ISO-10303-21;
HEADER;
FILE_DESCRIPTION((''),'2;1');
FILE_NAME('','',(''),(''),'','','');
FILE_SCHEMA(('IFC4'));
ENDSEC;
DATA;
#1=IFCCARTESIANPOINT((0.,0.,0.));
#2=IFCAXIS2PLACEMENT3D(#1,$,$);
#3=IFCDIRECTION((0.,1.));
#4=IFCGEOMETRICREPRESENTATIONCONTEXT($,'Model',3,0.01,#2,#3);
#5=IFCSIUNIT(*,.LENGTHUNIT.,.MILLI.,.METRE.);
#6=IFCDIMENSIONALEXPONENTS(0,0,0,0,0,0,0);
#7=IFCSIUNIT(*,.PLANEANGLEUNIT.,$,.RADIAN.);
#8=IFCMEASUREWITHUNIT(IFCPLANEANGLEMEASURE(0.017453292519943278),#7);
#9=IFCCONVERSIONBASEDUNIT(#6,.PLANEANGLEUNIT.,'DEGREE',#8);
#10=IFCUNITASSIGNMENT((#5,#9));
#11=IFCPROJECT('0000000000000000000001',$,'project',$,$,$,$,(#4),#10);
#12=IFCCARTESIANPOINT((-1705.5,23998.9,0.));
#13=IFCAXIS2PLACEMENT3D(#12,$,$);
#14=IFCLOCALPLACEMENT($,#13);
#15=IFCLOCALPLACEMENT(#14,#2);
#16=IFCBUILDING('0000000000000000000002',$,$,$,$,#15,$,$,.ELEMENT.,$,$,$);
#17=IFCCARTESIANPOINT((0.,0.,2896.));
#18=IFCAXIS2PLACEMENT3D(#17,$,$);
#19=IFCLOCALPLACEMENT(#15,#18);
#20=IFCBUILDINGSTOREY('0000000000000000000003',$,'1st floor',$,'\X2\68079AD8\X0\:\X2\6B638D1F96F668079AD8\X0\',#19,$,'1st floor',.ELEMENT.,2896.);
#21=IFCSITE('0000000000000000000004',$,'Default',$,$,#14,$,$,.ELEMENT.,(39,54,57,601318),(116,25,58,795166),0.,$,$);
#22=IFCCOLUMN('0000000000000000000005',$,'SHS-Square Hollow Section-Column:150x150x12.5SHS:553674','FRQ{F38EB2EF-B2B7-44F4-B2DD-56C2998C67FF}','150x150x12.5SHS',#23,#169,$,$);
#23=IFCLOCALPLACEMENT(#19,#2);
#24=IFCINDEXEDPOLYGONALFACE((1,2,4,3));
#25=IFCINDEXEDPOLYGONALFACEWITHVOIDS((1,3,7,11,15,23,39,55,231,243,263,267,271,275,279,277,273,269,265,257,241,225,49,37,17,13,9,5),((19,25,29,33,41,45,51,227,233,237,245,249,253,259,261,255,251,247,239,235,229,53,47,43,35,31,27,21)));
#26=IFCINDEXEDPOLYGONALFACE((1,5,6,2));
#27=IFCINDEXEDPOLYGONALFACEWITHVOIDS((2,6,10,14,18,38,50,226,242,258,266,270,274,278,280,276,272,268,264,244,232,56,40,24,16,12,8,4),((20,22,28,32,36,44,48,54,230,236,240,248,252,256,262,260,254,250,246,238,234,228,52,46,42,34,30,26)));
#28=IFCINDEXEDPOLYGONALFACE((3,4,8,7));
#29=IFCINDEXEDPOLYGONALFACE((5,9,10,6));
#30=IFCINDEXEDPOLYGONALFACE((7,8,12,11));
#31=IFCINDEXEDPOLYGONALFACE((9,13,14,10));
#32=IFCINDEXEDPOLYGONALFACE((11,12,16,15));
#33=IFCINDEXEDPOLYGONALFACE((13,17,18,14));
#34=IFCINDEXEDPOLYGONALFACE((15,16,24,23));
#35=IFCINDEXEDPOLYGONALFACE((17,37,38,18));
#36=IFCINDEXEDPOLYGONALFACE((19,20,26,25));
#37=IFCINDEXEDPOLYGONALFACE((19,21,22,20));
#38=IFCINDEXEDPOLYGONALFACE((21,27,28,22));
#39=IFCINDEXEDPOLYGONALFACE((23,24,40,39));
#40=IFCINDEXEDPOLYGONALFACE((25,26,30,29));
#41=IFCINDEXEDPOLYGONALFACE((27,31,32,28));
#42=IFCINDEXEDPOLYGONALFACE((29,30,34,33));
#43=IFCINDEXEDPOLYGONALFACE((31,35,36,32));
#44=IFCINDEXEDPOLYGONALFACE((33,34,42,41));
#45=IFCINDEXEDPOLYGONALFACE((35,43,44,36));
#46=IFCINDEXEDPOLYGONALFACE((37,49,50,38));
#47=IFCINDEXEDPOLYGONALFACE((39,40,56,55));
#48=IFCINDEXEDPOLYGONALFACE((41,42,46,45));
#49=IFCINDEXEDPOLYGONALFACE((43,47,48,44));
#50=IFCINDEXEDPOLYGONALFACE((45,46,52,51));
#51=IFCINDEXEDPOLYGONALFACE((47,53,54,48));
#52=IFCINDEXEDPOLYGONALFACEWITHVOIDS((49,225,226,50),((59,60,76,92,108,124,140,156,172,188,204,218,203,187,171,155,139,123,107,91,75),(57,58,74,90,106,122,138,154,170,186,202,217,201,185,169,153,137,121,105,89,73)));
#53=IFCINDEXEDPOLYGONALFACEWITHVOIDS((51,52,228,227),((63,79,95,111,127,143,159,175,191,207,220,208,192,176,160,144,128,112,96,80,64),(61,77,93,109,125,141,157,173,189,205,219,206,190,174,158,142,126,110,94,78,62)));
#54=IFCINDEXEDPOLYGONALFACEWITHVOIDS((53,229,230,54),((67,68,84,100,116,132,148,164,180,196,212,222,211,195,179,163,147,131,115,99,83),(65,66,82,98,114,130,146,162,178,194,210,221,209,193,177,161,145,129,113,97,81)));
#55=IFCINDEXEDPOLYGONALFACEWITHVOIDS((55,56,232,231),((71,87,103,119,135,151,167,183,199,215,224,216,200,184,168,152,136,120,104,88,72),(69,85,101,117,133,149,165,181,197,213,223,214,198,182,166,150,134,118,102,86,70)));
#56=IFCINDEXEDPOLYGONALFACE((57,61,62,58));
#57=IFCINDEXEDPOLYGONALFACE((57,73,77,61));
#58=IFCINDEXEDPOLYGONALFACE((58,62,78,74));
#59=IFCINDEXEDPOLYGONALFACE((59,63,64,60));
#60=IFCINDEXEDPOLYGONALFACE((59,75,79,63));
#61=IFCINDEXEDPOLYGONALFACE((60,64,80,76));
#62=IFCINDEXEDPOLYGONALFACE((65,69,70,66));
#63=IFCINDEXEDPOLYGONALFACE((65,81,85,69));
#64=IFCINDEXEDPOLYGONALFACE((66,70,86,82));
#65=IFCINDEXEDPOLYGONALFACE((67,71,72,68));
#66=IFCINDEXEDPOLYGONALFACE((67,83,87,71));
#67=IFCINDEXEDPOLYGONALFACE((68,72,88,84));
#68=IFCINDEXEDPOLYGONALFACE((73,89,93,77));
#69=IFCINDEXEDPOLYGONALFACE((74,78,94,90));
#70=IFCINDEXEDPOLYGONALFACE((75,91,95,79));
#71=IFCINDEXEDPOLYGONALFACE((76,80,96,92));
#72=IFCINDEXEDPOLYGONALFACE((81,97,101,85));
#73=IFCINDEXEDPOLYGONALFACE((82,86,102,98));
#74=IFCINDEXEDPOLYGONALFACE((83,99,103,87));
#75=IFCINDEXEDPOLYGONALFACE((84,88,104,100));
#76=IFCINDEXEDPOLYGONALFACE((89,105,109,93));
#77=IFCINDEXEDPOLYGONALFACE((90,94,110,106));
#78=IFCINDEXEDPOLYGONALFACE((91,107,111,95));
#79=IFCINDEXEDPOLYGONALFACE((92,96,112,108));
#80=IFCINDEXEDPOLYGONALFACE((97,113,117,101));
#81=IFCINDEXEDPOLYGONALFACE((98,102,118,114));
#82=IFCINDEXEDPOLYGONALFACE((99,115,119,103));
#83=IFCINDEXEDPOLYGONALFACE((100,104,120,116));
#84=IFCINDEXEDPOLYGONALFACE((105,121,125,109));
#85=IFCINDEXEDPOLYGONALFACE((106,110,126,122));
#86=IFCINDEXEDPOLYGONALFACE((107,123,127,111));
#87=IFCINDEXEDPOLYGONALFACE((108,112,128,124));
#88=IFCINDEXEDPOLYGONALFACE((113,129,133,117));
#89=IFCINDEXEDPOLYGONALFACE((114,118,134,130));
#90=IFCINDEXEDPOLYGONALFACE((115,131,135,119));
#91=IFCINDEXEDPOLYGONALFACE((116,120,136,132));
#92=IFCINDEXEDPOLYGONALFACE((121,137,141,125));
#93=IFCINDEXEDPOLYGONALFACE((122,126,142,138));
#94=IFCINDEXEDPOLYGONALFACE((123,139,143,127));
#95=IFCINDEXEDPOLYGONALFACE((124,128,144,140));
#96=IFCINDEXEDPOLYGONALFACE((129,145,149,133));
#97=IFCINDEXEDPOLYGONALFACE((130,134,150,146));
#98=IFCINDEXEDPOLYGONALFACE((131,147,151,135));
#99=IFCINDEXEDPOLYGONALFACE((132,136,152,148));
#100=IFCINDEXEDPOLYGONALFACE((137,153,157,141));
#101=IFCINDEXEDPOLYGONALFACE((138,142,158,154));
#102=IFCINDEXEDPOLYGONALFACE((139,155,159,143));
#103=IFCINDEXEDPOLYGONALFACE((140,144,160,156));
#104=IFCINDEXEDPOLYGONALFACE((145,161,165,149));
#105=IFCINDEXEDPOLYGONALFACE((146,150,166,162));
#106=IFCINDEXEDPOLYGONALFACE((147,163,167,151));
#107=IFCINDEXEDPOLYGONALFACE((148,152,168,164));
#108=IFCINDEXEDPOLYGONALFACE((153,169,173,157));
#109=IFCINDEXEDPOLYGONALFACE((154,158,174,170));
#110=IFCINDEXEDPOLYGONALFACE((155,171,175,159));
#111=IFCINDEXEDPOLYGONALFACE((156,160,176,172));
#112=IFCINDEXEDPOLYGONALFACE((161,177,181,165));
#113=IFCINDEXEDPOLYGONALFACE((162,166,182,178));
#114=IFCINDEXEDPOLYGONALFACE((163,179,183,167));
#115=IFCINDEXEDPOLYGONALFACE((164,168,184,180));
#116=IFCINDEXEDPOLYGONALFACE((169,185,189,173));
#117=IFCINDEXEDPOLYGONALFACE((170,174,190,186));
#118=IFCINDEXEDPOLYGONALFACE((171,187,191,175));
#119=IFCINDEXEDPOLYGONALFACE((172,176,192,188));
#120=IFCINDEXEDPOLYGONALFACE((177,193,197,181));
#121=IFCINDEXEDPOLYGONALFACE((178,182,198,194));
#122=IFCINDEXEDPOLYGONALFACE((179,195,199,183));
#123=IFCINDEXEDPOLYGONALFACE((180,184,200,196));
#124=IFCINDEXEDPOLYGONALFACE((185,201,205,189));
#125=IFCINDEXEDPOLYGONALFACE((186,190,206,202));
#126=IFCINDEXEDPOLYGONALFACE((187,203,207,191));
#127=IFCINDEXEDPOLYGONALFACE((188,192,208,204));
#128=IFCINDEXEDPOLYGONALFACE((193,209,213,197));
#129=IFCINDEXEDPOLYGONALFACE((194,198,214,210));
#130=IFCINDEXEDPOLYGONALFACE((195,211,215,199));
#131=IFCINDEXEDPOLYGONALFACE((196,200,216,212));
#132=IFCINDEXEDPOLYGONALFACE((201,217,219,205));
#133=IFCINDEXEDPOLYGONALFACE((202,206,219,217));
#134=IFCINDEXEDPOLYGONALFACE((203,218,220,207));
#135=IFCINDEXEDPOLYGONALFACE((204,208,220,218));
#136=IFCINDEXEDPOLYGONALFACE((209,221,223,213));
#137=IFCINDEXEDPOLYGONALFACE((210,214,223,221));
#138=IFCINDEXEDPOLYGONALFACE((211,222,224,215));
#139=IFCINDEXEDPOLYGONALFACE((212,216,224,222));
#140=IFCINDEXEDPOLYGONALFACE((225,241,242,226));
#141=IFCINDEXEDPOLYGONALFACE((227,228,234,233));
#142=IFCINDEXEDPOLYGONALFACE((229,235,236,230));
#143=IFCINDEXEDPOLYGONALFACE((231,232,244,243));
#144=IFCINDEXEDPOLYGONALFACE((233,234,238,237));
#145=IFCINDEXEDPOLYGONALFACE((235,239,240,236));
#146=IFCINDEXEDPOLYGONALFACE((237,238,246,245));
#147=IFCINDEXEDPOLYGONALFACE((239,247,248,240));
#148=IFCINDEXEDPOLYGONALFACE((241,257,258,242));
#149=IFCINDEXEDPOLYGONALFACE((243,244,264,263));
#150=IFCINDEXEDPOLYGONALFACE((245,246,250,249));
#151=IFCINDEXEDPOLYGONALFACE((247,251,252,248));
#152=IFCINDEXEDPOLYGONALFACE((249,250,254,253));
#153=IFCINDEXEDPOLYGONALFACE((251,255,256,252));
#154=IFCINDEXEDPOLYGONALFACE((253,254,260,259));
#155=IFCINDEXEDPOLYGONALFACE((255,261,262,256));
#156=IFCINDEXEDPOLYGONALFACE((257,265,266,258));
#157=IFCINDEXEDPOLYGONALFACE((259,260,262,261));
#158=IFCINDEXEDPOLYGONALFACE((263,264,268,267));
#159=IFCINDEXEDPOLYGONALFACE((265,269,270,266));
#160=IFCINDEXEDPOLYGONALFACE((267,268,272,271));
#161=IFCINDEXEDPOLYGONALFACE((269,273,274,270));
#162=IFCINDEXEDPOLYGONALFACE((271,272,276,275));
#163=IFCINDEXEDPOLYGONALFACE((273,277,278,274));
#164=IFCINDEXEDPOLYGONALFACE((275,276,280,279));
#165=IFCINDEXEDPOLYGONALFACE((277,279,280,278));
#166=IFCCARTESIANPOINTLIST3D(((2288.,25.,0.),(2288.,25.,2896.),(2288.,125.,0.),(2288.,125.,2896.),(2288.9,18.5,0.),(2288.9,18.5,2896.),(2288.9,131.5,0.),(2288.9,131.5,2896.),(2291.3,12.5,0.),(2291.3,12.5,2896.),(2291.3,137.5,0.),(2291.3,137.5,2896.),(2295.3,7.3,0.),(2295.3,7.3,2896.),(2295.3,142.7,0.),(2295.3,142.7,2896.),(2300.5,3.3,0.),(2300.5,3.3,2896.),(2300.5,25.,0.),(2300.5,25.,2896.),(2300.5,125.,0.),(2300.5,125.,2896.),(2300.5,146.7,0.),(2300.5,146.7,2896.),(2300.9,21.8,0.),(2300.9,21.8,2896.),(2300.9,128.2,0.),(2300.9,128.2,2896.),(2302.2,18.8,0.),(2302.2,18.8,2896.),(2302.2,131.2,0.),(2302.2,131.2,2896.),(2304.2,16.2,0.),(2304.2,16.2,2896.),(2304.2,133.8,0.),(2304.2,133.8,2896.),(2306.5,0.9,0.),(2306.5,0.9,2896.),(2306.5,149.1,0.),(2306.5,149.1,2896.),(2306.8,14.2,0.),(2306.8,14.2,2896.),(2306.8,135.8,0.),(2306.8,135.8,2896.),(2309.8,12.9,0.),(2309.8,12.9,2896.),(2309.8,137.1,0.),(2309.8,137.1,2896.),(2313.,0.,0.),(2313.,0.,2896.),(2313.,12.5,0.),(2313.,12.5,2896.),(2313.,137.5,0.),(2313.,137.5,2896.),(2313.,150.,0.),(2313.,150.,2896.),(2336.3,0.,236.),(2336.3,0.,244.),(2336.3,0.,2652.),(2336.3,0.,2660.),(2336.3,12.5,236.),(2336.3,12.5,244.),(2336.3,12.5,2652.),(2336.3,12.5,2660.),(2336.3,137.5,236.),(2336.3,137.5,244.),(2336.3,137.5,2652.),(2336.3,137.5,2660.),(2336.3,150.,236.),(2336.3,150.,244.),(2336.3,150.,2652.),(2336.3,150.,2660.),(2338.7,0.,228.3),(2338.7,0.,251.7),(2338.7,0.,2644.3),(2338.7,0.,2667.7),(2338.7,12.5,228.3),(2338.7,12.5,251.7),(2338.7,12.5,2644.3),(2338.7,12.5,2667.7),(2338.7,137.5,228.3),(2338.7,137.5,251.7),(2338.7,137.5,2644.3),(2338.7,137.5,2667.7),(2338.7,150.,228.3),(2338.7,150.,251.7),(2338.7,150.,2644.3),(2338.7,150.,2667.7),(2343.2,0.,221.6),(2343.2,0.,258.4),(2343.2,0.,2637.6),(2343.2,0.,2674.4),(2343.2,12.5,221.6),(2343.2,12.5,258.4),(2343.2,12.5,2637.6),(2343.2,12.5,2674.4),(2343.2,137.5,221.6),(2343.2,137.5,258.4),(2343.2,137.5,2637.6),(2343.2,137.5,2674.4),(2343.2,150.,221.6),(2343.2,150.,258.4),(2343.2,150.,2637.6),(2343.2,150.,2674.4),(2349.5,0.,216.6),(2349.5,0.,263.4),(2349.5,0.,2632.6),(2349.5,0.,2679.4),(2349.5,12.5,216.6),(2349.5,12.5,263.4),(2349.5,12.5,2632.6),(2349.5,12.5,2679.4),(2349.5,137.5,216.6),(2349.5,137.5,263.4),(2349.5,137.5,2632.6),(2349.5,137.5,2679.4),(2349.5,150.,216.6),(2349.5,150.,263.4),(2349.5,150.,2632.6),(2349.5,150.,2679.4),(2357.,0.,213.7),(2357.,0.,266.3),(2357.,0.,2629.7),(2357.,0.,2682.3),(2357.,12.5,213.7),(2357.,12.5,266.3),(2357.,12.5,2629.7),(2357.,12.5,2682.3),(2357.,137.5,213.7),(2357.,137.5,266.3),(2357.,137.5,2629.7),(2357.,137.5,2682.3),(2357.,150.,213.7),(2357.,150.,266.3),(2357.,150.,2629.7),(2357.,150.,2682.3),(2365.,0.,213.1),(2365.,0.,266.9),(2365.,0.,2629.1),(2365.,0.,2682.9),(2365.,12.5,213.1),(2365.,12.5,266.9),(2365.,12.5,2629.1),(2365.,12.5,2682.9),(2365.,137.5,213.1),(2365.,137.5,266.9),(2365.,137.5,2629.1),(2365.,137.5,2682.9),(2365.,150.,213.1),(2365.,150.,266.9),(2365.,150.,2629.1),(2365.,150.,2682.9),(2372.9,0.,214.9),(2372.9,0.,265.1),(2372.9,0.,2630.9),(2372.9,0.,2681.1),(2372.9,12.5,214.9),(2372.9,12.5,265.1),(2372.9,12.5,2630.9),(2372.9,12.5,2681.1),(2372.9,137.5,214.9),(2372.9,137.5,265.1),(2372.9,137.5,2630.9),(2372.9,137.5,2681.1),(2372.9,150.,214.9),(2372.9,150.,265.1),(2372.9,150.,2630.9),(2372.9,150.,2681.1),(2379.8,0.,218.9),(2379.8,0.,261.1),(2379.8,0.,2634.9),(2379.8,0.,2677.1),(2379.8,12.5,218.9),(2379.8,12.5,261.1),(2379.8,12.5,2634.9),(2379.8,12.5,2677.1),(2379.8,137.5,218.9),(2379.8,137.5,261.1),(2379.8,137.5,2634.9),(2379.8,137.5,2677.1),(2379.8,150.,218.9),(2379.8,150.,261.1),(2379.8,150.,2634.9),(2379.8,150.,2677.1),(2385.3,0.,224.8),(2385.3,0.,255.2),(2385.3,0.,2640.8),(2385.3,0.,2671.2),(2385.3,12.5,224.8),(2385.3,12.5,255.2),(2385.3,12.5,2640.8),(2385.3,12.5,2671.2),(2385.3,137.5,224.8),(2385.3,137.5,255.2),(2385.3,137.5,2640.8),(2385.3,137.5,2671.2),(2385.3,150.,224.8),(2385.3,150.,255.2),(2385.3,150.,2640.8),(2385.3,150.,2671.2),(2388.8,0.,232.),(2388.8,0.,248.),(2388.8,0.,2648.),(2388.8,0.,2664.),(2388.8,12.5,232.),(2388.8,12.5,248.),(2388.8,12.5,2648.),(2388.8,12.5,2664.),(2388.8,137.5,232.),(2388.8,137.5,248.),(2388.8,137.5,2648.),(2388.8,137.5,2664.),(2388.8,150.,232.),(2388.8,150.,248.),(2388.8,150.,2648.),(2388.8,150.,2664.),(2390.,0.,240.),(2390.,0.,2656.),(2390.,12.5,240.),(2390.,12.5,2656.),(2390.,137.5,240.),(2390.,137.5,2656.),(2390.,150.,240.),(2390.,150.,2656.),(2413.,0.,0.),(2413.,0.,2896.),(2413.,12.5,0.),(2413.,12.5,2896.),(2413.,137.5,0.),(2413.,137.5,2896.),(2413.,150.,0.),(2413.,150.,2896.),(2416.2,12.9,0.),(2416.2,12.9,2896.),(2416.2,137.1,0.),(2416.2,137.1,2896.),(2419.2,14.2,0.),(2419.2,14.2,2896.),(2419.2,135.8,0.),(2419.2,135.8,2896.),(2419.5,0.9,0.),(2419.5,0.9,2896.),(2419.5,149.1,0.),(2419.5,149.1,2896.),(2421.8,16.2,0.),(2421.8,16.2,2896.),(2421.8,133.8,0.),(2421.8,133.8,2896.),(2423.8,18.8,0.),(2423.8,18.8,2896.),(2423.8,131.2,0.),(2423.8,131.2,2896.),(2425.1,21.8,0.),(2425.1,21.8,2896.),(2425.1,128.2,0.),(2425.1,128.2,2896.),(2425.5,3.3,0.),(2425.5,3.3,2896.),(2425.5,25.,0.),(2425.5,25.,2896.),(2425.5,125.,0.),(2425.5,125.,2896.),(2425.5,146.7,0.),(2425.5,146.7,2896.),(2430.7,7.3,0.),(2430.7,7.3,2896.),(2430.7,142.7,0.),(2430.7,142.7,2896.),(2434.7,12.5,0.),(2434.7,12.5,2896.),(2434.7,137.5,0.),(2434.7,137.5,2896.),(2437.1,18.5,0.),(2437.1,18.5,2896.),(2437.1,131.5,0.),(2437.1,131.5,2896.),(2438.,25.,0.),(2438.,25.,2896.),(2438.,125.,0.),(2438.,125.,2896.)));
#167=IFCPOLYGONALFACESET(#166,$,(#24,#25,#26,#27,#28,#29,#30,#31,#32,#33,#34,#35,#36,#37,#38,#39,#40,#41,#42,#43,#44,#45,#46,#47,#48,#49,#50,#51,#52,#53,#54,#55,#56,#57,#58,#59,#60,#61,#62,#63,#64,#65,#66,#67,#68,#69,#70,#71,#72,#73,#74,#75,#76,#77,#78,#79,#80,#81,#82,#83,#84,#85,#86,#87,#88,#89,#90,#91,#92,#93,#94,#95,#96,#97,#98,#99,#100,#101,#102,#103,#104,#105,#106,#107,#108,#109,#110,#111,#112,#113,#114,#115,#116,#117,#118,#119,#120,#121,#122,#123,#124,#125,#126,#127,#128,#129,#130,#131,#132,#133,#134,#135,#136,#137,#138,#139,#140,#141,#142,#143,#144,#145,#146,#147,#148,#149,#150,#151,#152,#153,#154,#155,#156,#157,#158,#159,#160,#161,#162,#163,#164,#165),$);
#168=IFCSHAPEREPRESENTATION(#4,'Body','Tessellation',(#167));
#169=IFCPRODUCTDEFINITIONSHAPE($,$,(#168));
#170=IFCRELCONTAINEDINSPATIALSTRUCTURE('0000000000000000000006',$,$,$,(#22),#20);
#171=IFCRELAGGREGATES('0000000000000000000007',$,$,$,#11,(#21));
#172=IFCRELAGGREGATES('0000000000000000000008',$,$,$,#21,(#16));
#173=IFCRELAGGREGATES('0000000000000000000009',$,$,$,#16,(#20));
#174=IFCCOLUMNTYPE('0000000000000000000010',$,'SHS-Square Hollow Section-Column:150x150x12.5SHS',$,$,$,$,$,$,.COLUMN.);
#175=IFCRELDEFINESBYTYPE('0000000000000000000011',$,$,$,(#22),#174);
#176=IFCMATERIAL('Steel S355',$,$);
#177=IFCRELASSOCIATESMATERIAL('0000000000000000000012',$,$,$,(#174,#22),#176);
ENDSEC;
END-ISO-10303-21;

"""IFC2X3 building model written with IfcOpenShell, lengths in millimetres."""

from ifc_helpers import new_model, entity, si_unit, converted_unit, direction, frame, frame_2d, origin, origin_2d, place, context, project, spatial, circle_curve, hollow_rectangle, outline, extrude, material, type_object, element, save


model = new_model("IFC2X3")

# Units and contexts
model_context = context("Model", 3, precision=0.01, world=origin(), true_north=direction((0.0, 1.0)))
ifc_project = project(units=[si_unit("LENGTHUNIT", "METRE", prefix="MILLI"), converted_unit("PLANEANGLEUNIT", "DEGREE", entity("IfcPlaneAngleMeasure", 0.017453292519943278), si_unit("PLANEANGLEUNIT", "RADIAN"), dimensions=[0, 0, 0, 0, 0, 0, 0])], contexts=[model_context])

# Site, building, storey
site_placement = place(None, frame((-1705.5, 23998.9, 0.0)))
site = spatial("IfcSite", under=ifc_project, at=site_placement, Name="Default", CompositionType="ELEMENT", RefLatitude=(39, 54, 57, 601318), RefLongitude=(116, 25, 58, 795166), RefElevation=0.0)
building_placement = place(site_placement, origin())
building = spatial("IfcBuilding", under=site, at=building_placement, CompositionType="ELEMENT")
storey_placement = place(building_placement, frame((0.0, 0.0, 2896.0)))
storey = spatial("IfcBuildingStorey", under=building, at=storey_placement, Name="1st floor", ObjectType="标高:正负零标高", LongName="1st floor", CompositionType="ELEMENT", Elevation=2896.0)

# Column, openings
ifc_material_1 = material(Name="Steel S355")
column_type_1 = type_object("IfcColumnType", Name="SHS-Square Hollow Section-Column:150x150x12.5SHS", PredefinedType="COLUMN", material=ifc_material_1)
column_1_placement = place(storey_placement, frame((2363.0, 75.0, 2896.0), z_axis=(0.0, 0.0, 1.0), x_axis=(0.0, -1.0, 0.0)))
column_1 = element("IfcColumn", 1, at=column_1_placement, inside=storey, type_object=column_type_1, material=ifc_material_1, Name="SHS-Square Hollow Section-Column:150x150x12.5SHS:553674", Description="FRQ{F38EB2EF-B2B7-44F4-B2DD-56C2998C67FF}", ObjectType="150x150x12.5SHS", context=model_context, shape_type="SweptSolid", body=[
    extrude(hollow_rectangle(XDim=150.0, YDim=150.0, WallThickness=12.5, InnerFilletRadius=12.5, OuterFilletRadius=25.0, at=origin_2d()), origin(), (0.0, 0.0, -1.0), 2896.0),
])
opening_1_placement = place(column_1_placement, frame((-175.1, 0.0, -2896.0), z_axis=(1.0, 0.0, 0.0), x_axis=(0.0, 1.0, 0.0)))
element("IfcOpeningElement", 2, at=opening_1_placement, cuts=column_1, ObjectType="Opening", context=model_context, shape_type="SweptSolid", body=[
    extrude(outline(circle_curve(frame_2d((0.0, 240.0), x_axis=(1.0, 0.0)), 27.0)), origin(), (0.0, 0.0, 1.0), 350.2),
])
opening_2_placement = place(column_1_placement, frame((-175.1, 0.0, 0.0), z_axis=(1.0, 0.0, 0.0), x_axis=(0.0, 1.0, 0.0)))
element("IfcOpeningElement", 3, at=opening_2_placement, cuts=column_1, ObjectType="Opening", context=model_context, shape_type="SweptSolid", body=[
    extrude(outline(circle_curve(frame_2d((0.0, -240.0), x_axis=(1.0, 0.0)), 27.0)), origin(), (0.0, 0.0, 1.0), 350.2),
])

save(model, "model.ifc")
